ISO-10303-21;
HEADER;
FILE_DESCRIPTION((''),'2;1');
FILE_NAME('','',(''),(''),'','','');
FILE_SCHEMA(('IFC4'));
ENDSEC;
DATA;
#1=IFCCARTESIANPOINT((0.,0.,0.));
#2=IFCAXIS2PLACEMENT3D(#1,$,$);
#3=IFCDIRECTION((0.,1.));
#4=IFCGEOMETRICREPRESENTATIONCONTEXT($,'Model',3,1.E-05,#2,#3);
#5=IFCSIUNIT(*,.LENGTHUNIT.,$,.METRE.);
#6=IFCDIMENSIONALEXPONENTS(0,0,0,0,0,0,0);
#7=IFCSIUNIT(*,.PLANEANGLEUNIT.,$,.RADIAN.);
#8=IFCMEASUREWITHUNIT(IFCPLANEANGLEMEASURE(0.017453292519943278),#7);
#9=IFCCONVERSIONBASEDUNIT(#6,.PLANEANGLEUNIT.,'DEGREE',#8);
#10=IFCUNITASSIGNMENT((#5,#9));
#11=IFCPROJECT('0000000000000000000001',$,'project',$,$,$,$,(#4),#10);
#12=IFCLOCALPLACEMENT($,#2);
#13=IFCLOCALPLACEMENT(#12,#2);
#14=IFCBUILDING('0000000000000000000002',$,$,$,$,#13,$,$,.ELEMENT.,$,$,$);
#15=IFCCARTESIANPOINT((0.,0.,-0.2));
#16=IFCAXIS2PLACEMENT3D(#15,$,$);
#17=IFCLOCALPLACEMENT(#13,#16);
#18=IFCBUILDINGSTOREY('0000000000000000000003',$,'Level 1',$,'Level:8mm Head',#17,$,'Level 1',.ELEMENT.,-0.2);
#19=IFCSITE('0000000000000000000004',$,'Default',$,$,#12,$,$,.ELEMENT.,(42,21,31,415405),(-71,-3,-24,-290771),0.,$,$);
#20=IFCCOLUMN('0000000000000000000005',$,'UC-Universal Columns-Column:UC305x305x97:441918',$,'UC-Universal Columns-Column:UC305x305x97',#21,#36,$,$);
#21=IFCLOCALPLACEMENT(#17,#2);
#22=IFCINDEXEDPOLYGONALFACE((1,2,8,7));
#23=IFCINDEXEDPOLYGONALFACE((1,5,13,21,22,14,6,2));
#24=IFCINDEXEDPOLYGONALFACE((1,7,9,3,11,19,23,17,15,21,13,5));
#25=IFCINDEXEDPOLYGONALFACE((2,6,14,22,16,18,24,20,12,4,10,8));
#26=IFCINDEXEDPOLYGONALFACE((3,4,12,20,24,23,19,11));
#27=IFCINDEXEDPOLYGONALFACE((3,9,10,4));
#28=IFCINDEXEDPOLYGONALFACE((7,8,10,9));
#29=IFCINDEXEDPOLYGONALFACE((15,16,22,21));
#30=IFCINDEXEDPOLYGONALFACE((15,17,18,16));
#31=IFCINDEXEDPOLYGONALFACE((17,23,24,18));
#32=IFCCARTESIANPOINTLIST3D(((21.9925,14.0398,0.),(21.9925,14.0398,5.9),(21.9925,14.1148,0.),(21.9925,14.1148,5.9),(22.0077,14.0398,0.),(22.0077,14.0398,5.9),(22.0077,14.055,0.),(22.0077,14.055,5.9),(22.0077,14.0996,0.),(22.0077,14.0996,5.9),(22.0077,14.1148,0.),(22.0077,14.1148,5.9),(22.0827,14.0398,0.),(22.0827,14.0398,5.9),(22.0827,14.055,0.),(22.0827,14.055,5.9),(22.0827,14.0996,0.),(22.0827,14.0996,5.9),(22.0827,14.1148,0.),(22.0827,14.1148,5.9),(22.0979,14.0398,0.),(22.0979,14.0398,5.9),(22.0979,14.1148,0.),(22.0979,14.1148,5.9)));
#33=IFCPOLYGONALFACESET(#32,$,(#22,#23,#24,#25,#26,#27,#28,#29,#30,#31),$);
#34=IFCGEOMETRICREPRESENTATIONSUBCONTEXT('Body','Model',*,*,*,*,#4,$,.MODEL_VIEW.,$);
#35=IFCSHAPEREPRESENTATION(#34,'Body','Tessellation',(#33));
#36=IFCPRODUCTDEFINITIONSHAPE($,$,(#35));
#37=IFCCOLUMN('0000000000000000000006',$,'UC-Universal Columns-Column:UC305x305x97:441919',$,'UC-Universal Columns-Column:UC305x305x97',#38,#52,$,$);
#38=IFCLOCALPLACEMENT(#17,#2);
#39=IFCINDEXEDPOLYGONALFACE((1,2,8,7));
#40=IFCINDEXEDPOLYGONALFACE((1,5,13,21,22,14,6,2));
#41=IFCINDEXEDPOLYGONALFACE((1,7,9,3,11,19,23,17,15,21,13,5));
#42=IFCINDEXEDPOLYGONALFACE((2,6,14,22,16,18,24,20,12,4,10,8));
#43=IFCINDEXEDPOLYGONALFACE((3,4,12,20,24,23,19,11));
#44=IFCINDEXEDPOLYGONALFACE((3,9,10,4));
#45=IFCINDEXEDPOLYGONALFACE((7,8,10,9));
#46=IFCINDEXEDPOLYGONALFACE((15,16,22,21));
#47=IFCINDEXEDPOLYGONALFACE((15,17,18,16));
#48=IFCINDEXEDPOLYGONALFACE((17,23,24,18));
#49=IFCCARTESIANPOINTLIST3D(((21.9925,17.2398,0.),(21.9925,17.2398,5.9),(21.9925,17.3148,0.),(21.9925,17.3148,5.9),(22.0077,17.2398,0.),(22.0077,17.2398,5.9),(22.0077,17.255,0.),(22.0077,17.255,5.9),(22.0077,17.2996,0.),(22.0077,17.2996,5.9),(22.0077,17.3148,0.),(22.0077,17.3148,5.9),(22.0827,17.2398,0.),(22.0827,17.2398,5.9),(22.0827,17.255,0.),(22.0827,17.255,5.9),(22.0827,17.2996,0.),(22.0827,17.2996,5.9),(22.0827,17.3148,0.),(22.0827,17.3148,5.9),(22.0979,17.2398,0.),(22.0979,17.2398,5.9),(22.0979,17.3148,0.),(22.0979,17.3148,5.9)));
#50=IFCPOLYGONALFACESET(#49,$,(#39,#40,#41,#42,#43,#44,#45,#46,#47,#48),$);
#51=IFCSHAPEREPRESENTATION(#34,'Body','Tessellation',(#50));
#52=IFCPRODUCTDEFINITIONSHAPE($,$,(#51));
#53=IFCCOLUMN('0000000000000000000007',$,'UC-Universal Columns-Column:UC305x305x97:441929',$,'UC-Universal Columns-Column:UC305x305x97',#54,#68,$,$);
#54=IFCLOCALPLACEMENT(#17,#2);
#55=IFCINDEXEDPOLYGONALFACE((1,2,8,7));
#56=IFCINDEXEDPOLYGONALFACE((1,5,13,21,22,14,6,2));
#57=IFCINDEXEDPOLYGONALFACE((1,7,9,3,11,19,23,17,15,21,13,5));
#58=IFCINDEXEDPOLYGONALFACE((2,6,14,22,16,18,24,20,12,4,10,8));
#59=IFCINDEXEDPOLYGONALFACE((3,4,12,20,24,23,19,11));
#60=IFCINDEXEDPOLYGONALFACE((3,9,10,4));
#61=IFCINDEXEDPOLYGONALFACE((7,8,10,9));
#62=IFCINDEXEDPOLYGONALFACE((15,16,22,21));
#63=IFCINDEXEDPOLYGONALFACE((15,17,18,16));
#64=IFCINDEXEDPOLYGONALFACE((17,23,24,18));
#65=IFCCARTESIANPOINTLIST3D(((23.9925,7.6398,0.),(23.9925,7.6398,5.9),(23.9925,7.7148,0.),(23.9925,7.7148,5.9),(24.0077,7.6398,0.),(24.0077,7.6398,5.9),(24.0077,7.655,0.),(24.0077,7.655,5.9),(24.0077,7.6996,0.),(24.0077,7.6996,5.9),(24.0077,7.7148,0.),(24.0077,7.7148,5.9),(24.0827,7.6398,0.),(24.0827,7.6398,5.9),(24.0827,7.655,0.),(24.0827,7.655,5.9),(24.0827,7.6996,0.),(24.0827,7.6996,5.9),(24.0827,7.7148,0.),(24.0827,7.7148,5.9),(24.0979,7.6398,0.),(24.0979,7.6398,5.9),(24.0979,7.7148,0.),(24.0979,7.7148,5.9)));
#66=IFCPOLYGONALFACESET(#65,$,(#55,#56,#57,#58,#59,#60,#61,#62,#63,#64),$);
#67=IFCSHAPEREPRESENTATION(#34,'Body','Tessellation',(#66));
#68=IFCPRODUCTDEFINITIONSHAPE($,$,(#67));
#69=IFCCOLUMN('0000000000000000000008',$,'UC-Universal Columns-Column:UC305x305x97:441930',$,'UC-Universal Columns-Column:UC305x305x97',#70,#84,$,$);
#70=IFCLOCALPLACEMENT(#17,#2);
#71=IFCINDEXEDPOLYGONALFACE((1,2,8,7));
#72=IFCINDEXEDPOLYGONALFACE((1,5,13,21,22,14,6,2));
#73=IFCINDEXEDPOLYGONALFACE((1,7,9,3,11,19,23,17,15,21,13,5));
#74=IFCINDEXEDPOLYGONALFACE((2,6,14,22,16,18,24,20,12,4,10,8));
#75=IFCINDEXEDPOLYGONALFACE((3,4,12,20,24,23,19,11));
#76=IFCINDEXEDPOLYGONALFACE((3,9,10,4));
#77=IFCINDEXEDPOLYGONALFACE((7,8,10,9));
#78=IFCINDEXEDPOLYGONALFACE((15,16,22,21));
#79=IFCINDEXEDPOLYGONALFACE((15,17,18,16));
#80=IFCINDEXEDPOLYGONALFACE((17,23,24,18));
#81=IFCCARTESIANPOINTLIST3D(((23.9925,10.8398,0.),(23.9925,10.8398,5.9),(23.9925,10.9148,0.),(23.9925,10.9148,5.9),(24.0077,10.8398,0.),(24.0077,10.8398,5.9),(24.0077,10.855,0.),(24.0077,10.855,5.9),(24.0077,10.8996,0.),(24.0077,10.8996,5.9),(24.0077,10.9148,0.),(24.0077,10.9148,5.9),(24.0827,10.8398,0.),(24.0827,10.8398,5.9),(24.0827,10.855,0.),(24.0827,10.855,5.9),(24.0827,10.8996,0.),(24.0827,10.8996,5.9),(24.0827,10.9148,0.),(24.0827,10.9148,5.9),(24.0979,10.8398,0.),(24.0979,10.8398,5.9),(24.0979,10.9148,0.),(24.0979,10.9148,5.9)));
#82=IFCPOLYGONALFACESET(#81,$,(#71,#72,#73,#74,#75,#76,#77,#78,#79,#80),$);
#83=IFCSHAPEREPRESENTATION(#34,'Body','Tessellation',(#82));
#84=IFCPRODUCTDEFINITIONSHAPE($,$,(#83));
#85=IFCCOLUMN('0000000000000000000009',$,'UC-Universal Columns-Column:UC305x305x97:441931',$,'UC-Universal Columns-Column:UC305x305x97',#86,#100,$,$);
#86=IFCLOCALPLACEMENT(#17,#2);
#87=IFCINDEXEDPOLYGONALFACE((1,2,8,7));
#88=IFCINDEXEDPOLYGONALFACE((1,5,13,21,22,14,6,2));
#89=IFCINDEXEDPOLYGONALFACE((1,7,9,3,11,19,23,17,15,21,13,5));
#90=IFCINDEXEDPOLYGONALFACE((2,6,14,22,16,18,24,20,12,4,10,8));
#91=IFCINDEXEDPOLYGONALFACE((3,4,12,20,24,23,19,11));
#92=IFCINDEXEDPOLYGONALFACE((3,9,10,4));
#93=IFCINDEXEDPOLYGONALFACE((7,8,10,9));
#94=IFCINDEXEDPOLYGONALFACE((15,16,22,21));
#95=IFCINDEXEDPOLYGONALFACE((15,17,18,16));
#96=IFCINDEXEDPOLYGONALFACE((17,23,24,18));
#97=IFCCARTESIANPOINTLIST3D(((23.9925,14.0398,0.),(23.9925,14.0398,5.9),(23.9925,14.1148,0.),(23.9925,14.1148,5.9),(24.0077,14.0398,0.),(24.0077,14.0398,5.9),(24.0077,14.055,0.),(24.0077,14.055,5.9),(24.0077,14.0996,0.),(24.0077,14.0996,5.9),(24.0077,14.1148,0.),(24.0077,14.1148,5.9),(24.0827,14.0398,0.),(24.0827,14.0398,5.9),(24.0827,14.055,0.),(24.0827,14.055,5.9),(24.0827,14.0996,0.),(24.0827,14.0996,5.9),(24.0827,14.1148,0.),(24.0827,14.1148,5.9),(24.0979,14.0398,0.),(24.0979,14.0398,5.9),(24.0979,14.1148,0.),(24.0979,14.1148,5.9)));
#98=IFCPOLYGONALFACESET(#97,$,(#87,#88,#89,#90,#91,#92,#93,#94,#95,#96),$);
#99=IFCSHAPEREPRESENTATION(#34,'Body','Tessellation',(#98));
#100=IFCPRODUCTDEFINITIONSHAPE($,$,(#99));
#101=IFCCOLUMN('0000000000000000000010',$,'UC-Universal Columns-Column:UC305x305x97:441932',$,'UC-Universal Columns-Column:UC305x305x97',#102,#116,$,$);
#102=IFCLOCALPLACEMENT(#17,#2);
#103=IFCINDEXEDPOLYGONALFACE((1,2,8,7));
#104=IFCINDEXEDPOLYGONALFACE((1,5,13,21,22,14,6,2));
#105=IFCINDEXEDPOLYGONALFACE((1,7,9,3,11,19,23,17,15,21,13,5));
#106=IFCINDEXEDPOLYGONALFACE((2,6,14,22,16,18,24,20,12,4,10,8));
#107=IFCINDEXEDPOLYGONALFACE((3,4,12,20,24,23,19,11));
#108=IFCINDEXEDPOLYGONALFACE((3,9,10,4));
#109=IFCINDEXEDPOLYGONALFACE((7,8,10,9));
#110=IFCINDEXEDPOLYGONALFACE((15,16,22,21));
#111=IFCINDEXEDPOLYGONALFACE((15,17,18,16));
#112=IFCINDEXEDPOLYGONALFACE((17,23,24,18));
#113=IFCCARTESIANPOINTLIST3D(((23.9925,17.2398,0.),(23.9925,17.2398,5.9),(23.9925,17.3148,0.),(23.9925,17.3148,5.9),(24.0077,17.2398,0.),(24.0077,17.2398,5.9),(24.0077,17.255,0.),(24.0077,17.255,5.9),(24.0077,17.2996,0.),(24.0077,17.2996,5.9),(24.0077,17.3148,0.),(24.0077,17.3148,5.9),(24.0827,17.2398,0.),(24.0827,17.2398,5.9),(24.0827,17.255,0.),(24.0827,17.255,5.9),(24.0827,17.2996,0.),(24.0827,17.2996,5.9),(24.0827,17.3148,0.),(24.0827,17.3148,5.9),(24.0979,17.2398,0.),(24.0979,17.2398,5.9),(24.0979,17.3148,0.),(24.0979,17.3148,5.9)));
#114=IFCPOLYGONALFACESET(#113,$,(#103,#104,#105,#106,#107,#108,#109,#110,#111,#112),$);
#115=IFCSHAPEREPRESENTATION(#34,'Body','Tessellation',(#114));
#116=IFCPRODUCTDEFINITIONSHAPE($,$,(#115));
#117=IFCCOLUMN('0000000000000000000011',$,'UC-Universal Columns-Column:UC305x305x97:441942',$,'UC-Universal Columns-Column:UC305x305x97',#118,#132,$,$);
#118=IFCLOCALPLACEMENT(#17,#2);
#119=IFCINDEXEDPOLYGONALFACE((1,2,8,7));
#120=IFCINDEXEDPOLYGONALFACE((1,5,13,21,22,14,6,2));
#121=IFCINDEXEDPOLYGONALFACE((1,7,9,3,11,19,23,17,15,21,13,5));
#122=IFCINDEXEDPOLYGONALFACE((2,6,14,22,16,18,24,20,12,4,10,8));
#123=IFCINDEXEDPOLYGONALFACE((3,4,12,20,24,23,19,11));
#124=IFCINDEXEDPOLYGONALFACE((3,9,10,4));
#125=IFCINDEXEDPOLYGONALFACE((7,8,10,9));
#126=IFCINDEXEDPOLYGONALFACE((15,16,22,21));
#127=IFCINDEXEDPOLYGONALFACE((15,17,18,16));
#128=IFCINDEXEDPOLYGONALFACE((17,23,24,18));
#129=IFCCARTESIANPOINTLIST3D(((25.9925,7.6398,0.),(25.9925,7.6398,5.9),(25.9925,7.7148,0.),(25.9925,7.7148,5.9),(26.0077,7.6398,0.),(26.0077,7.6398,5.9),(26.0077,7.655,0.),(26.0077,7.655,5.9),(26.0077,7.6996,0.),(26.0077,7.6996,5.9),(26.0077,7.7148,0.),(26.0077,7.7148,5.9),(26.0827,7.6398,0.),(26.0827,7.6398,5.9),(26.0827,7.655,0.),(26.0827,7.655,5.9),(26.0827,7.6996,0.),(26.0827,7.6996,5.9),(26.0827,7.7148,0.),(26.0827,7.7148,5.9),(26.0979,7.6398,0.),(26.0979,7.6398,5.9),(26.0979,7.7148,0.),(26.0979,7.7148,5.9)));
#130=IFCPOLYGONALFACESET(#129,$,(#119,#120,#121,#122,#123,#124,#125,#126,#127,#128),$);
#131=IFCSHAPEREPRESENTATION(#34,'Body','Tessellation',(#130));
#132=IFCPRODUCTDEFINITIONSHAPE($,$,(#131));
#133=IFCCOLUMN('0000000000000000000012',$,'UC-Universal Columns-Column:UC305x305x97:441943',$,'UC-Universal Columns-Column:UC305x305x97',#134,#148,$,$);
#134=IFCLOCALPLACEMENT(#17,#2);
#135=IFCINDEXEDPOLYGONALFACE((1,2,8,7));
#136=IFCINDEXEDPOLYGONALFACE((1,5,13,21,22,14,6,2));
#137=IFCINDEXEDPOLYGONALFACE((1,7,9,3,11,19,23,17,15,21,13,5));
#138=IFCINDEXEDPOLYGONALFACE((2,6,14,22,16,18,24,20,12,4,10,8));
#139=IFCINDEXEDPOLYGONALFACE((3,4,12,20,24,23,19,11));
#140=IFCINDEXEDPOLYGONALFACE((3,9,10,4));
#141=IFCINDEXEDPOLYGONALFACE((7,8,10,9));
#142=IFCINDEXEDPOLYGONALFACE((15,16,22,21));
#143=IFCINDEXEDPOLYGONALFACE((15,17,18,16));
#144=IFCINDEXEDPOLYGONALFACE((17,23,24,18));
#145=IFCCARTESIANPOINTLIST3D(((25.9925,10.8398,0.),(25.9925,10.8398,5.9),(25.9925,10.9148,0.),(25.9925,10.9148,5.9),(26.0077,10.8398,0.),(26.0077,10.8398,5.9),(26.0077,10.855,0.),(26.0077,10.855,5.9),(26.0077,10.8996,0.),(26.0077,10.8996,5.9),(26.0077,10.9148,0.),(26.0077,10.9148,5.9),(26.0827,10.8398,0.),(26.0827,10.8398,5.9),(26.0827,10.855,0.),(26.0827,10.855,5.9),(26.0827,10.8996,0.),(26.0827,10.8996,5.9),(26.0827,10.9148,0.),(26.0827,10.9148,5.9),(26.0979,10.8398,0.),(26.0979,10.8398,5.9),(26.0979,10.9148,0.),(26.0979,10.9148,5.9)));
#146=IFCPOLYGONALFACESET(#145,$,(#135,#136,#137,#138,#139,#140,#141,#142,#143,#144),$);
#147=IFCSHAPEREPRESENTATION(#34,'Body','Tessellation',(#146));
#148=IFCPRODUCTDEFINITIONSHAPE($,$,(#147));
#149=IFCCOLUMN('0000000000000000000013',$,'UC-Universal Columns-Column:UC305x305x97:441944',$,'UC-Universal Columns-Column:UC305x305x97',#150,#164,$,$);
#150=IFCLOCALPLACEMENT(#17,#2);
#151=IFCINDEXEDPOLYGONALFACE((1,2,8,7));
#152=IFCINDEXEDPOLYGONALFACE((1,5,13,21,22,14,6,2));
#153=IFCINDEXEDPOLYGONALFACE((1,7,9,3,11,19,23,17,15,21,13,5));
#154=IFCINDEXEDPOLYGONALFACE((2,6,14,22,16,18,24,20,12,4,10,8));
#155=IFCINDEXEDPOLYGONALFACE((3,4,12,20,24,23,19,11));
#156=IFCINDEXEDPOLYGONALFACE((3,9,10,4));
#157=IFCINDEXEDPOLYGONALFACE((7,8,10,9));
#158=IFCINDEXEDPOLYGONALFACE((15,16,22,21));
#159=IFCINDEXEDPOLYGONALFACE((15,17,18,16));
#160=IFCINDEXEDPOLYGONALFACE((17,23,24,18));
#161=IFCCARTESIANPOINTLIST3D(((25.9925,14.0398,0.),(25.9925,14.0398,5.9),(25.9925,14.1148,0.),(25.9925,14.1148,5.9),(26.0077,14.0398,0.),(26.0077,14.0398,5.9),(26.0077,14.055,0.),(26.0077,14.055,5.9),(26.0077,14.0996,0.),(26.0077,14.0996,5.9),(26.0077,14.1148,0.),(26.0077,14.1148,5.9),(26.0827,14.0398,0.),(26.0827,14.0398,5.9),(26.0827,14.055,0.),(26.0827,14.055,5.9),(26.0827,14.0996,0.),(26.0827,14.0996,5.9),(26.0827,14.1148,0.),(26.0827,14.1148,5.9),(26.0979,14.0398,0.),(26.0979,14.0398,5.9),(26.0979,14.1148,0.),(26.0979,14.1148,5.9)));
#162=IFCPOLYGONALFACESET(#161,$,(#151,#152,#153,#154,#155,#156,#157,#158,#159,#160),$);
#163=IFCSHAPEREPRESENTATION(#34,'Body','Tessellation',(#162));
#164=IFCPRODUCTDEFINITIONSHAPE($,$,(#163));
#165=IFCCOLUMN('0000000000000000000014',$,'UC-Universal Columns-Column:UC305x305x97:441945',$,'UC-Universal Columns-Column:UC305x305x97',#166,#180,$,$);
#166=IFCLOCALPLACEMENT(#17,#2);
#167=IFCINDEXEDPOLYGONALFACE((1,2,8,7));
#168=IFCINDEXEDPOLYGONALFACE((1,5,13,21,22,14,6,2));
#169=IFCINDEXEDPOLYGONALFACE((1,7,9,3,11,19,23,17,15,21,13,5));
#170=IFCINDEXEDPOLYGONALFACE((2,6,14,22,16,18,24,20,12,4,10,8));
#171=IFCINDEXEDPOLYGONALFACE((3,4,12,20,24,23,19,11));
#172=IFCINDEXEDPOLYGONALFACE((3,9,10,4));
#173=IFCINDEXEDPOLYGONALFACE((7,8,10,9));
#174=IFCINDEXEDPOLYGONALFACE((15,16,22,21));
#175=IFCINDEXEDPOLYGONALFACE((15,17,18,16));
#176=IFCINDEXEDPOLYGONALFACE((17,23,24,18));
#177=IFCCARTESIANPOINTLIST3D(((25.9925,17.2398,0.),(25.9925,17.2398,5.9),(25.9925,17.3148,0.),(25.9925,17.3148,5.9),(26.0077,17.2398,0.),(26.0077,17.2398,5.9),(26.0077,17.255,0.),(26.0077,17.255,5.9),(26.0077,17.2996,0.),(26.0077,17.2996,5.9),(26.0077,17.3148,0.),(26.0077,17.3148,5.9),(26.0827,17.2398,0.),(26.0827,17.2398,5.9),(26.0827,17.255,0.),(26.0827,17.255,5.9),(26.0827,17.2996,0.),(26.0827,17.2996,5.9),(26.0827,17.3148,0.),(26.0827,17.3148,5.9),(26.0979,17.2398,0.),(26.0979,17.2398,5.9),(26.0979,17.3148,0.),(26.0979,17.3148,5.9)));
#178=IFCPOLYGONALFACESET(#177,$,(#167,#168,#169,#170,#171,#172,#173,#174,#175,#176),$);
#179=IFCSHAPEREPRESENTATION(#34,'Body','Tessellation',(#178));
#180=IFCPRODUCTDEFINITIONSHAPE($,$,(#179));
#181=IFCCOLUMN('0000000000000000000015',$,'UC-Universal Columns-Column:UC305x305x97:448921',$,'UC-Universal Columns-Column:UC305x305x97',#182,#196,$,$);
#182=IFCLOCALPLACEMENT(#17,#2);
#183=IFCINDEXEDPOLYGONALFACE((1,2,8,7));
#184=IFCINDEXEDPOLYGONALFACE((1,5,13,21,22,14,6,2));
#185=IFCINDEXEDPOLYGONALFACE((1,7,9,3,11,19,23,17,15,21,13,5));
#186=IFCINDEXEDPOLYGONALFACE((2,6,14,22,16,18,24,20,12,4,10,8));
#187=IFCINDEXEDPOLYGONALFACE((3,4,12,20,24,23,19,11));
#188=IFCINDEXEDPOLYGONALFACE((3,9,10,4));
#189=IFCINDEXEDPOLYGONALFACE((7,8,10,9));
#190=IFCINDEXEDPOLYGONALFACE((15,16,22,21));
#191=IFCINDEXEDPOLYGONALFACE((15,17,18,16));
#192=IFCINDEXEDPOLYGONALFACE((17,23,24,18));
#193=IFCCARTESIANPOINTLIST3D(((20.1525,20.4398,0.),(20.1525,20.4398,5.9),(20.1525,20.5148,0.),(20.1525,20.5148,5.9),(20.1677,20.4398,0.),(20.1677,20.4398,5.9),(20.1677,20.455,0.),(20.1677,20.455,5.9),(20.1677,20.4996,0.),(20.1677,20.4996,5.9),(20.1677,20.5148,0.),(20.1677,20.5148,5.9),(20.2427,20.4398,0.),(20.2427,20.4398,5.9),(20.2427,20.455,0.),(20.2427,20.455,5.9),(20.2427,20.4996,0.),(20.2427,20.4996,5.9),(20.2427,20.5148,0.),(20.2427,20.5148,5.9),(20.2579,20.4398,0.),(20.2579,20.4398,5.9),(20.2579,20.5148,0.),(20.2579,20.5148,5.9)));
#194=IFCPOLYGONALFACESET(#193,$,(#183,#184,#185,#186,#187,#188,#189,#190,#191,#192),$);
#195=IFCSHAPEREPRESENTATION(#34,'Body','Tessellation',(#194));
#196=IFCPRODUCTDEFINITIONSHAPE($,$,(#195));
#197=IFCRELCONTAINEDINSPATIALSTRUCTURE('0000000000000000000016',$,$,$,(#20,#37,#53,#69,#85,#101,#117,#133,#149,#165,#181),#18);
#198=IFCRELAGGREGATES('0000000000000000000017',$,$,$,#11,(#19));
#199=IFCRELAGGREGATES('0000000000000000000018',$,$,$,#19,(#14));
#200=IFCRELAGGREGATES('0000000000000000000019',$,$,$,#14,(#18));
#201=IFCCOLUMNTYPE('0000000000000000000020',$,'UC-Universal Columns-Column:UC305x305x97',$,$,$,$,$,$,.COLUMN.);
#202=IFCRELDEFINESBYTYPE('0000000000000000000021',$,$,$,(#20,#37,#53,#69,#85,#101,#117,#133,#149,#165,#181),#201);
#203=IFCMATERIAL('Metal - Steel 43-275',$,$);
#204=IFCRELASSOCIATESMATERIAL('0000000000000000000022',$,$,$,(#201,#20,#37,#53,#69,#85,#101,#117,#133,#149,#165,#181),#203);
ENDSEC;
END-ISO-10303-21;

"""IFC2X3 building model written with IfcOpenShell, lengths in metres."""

from ifc_helpers import new_model, entity, si_unit, converted_unit, direction, frame, frame_2d, origin, place, context, subcontext, project, spatial, polyline, circle_curve, parameter, trimmed, segment, composite_curve, outline, extrude, source, transform, mapped, material, type_object, type_shapes, element, save


model = new_model("IFC2X3")

# Units and contexts
model_context = context("Model", 3, precision=1e-05, world=origin(), true_north=direction((0.0, 1.0)))
body_context = subcontext(model_context, "Body", "Model", "MODEL_VIEW")
ifc_project = project(units=[si_unit("LENGTHUNIT", "METRE"), converted_unit("PLANEANGLEUNIT", "DEGREE", entity("IfcPlaneAngleMeasure", 0.017453292519943278), si_unit("PLANEANGLEUNIT", "RADIAN"), dimensions=[0, 0, 0, 0, 0, 0, 0])], contexts=[model_context])

# Site, building, storey
site_placement = place(None, origin())
site = spatial("IfcSite", under=ifc_project, at=site_placement, Name="Default", CompositionType="ELEMENT", RefLatitude=(42, 21, 31, 415405), RefLongitude=(-71, -3, -24, -290771), RefElevation=0.0)
building_placement = place(site_placement, origin())
building = spatial("IfcBuilding", under=site, at=building_placement, CompositionType="ELEMENT")
storey_placement = place(building_placement, frame((0.0, 0.0, -0.2)))
storey = spatial("IfcBuildingStorey", under=building, at=storey_placement, Name="Level 1", ObjectType="Level:8mm Head", LongName="Level 1", CompositionType="ELEMENT", Elevation=-0.2)

# Columns
ifc_material = material(Name="Metal - Steel 43-275")
column_type = type_object("IfcColumnType", Name="UC-Universal Columns-Column:UC305x305x97", PredefinedType="COLUMN", material=ifc_material)
shared_shape = source(origin(), body_context, "Body", "SweptSolid", [
    extrude(outline(composite_curve([segment(polyline([(-0.0375, -0.0375), (0.0375, -0.0375)]), True, "CONTINUOUS"), segment(polyline([(0.0375, -0.0375), (0.0527, -0.0375)]), True, "CONTINUOUS"), segment(trimmed(circle_curve(frame_2d((0.0527, -0.0223), x_axis=(-1.0, 0.0)), 0.0152), [parameter(0.0)], [parameter(90.0)], True, "PARAMETER"), False, "CONTINUOUS"), segment(polyline([(0.0375, -0.0223), (0.0375, 0.0223)]), True, "CONTINUOUS"), segment(trimmed(circle_curve(frame_2d((0.0527, 0.0223), x_axis=(-1.0, 0.0)), 0.0152), [parameter(270.0)], [parameter(0.0)], True, "PARAMETER"), False, "CONTINUOUS"), segment(polyline([(0.0527, 0.0375), (0.0375, 0.0375)]), True, "CONTINUOUS"), segment(polyline([(0.0375, 0.0375), (-0.0375, 0.0375)]), True, "CONTINUOUS"), segment(polyline([(-0.0375, 0.0375), (-0.0527, 0.0375)]), True, "CONTINUOUS"), segment(trimmed(circle_curve(frame_2d((-0.0527, 0.0223), x_axis=(-1.0, 0.0)), 0.0152), [parameter(180.0)], [parameter(270.0)], True, "PARAMETER"), False, "CONTINUOUS"), segment(polyline([(-0.0375, 0.0223), (-0.0375, -0.0223)]), True, "CONTINUOUS"), segment(trimmed(circle_curve(frame_2d((-0.0527, -0.0223), x_axis=(-1.0, 0.0)), 0.0152), [parameter(90.0)], [parameter(180.0)], True, "PARAMETER"), False, "CONTINUOUS"), segment(polyline([(-0.0527, -0.0375), (-0.0375, -0.0375)]), True, "CONTINUOUS")], self_intersect=False)), frame((0.0, 0.0, -0.2), z_axis=(0.0, 0.0, 1.0), x_axis=(-1.0, 0.0, 0.0)), (0.0, 0.0, 1.0), 5.9),
])
type_shapes(column_type, [shared_shape])
for number, where, z_axis, x_axis, name in (
    (1, (22.0452, 14.0773, 0.2), (0.0, 0.0, 1.0), (-1.0, 0.0, 0.0), "UC-Universal Columns-Column:UC305x305x97:441918"),
    (2, (22.0452, 17.2773, 0.2), (0.0, 0.0, 1.0), (-1.0, 0.0, 0.0), "UC-Universal Columns-Column:UC305x305x97:441919"),
    (3, (24.0452, 7.6773, 0.2), (0.0, 0.0, 1.0), (-1.0, 0.0, 0.0), "UC-Universal Columns-Column:UC305x305x97:441929"),
    (4, (24.0452, 10.8773, 0.2), (0.0, 0.0, 1.0), (-1.0, 0.0, 0.0), "UC-Universal Columns-Column:UC305x305x97:441930"),
    (5, (24.0452, 14.0773, 0.2), (0.0, 0.0, 1.0), (-1.0, 0.0, 0.0), "UC-Universal Columns-Column:UC305x305x97:441931"),
    (6, (24.0452, 17.2773, 0.2), (0.0, 0.0, 1.0), (-1.0, 0.0, 0.0), "UC-Universal Columns-Column:UC305x305x97:441932"),
    (7, (26.0452, 7.6773, 0.2), (0.0, 0.0, 1.0), (-1.0, 0.0, 0.0), "UC-Universal Columns-Column:UC305x305x97:441942"),
    (8, (26.0452, 10.8773, 0.2), (0.0, 0.0, 1.0), (-1.0, 0.0, 0.0), "UC-Universal Columns-Column:UC305x305x97:441943"),
    (9, (26.0452, 14.0773, 0.2), (0.0, 0.0, 1.0), (-1.0, 0.0, 0.0), "UC-Universal Columns-Column:UC305x305x97:441944"),
    (10, (26.0452, 17.2773, 0.2), (0.0, 0.0, 1.0), (-1.0, 0.0, 0.0), "UC-Universal Columns-Column:UC305x305x97:441945"),
    (11, (20.2052, 20.4773, 0.2), (0.0, 0.0, 1.0), (-1.0, 0.0, 0.0), "UC-Universal Columns-Column:UC305x305x97:448921"),
):
    element("IfcColumn", number, at=place(storey_placement, frame(where, z_axis=z_axis, x_axis=x_axis)), inside=storey, type_object=column_type, material=ifc_material, Name=name, ObjectType="UC-Universal Columns-Column:UC305x305x97", context=body_context, shape_type="MappedRepresentation", body=[
        mapped(shared_shape, transform((0.0, 0.0, 0.0), scale=1.0)),
    ])

save(model, "model.ifc")
